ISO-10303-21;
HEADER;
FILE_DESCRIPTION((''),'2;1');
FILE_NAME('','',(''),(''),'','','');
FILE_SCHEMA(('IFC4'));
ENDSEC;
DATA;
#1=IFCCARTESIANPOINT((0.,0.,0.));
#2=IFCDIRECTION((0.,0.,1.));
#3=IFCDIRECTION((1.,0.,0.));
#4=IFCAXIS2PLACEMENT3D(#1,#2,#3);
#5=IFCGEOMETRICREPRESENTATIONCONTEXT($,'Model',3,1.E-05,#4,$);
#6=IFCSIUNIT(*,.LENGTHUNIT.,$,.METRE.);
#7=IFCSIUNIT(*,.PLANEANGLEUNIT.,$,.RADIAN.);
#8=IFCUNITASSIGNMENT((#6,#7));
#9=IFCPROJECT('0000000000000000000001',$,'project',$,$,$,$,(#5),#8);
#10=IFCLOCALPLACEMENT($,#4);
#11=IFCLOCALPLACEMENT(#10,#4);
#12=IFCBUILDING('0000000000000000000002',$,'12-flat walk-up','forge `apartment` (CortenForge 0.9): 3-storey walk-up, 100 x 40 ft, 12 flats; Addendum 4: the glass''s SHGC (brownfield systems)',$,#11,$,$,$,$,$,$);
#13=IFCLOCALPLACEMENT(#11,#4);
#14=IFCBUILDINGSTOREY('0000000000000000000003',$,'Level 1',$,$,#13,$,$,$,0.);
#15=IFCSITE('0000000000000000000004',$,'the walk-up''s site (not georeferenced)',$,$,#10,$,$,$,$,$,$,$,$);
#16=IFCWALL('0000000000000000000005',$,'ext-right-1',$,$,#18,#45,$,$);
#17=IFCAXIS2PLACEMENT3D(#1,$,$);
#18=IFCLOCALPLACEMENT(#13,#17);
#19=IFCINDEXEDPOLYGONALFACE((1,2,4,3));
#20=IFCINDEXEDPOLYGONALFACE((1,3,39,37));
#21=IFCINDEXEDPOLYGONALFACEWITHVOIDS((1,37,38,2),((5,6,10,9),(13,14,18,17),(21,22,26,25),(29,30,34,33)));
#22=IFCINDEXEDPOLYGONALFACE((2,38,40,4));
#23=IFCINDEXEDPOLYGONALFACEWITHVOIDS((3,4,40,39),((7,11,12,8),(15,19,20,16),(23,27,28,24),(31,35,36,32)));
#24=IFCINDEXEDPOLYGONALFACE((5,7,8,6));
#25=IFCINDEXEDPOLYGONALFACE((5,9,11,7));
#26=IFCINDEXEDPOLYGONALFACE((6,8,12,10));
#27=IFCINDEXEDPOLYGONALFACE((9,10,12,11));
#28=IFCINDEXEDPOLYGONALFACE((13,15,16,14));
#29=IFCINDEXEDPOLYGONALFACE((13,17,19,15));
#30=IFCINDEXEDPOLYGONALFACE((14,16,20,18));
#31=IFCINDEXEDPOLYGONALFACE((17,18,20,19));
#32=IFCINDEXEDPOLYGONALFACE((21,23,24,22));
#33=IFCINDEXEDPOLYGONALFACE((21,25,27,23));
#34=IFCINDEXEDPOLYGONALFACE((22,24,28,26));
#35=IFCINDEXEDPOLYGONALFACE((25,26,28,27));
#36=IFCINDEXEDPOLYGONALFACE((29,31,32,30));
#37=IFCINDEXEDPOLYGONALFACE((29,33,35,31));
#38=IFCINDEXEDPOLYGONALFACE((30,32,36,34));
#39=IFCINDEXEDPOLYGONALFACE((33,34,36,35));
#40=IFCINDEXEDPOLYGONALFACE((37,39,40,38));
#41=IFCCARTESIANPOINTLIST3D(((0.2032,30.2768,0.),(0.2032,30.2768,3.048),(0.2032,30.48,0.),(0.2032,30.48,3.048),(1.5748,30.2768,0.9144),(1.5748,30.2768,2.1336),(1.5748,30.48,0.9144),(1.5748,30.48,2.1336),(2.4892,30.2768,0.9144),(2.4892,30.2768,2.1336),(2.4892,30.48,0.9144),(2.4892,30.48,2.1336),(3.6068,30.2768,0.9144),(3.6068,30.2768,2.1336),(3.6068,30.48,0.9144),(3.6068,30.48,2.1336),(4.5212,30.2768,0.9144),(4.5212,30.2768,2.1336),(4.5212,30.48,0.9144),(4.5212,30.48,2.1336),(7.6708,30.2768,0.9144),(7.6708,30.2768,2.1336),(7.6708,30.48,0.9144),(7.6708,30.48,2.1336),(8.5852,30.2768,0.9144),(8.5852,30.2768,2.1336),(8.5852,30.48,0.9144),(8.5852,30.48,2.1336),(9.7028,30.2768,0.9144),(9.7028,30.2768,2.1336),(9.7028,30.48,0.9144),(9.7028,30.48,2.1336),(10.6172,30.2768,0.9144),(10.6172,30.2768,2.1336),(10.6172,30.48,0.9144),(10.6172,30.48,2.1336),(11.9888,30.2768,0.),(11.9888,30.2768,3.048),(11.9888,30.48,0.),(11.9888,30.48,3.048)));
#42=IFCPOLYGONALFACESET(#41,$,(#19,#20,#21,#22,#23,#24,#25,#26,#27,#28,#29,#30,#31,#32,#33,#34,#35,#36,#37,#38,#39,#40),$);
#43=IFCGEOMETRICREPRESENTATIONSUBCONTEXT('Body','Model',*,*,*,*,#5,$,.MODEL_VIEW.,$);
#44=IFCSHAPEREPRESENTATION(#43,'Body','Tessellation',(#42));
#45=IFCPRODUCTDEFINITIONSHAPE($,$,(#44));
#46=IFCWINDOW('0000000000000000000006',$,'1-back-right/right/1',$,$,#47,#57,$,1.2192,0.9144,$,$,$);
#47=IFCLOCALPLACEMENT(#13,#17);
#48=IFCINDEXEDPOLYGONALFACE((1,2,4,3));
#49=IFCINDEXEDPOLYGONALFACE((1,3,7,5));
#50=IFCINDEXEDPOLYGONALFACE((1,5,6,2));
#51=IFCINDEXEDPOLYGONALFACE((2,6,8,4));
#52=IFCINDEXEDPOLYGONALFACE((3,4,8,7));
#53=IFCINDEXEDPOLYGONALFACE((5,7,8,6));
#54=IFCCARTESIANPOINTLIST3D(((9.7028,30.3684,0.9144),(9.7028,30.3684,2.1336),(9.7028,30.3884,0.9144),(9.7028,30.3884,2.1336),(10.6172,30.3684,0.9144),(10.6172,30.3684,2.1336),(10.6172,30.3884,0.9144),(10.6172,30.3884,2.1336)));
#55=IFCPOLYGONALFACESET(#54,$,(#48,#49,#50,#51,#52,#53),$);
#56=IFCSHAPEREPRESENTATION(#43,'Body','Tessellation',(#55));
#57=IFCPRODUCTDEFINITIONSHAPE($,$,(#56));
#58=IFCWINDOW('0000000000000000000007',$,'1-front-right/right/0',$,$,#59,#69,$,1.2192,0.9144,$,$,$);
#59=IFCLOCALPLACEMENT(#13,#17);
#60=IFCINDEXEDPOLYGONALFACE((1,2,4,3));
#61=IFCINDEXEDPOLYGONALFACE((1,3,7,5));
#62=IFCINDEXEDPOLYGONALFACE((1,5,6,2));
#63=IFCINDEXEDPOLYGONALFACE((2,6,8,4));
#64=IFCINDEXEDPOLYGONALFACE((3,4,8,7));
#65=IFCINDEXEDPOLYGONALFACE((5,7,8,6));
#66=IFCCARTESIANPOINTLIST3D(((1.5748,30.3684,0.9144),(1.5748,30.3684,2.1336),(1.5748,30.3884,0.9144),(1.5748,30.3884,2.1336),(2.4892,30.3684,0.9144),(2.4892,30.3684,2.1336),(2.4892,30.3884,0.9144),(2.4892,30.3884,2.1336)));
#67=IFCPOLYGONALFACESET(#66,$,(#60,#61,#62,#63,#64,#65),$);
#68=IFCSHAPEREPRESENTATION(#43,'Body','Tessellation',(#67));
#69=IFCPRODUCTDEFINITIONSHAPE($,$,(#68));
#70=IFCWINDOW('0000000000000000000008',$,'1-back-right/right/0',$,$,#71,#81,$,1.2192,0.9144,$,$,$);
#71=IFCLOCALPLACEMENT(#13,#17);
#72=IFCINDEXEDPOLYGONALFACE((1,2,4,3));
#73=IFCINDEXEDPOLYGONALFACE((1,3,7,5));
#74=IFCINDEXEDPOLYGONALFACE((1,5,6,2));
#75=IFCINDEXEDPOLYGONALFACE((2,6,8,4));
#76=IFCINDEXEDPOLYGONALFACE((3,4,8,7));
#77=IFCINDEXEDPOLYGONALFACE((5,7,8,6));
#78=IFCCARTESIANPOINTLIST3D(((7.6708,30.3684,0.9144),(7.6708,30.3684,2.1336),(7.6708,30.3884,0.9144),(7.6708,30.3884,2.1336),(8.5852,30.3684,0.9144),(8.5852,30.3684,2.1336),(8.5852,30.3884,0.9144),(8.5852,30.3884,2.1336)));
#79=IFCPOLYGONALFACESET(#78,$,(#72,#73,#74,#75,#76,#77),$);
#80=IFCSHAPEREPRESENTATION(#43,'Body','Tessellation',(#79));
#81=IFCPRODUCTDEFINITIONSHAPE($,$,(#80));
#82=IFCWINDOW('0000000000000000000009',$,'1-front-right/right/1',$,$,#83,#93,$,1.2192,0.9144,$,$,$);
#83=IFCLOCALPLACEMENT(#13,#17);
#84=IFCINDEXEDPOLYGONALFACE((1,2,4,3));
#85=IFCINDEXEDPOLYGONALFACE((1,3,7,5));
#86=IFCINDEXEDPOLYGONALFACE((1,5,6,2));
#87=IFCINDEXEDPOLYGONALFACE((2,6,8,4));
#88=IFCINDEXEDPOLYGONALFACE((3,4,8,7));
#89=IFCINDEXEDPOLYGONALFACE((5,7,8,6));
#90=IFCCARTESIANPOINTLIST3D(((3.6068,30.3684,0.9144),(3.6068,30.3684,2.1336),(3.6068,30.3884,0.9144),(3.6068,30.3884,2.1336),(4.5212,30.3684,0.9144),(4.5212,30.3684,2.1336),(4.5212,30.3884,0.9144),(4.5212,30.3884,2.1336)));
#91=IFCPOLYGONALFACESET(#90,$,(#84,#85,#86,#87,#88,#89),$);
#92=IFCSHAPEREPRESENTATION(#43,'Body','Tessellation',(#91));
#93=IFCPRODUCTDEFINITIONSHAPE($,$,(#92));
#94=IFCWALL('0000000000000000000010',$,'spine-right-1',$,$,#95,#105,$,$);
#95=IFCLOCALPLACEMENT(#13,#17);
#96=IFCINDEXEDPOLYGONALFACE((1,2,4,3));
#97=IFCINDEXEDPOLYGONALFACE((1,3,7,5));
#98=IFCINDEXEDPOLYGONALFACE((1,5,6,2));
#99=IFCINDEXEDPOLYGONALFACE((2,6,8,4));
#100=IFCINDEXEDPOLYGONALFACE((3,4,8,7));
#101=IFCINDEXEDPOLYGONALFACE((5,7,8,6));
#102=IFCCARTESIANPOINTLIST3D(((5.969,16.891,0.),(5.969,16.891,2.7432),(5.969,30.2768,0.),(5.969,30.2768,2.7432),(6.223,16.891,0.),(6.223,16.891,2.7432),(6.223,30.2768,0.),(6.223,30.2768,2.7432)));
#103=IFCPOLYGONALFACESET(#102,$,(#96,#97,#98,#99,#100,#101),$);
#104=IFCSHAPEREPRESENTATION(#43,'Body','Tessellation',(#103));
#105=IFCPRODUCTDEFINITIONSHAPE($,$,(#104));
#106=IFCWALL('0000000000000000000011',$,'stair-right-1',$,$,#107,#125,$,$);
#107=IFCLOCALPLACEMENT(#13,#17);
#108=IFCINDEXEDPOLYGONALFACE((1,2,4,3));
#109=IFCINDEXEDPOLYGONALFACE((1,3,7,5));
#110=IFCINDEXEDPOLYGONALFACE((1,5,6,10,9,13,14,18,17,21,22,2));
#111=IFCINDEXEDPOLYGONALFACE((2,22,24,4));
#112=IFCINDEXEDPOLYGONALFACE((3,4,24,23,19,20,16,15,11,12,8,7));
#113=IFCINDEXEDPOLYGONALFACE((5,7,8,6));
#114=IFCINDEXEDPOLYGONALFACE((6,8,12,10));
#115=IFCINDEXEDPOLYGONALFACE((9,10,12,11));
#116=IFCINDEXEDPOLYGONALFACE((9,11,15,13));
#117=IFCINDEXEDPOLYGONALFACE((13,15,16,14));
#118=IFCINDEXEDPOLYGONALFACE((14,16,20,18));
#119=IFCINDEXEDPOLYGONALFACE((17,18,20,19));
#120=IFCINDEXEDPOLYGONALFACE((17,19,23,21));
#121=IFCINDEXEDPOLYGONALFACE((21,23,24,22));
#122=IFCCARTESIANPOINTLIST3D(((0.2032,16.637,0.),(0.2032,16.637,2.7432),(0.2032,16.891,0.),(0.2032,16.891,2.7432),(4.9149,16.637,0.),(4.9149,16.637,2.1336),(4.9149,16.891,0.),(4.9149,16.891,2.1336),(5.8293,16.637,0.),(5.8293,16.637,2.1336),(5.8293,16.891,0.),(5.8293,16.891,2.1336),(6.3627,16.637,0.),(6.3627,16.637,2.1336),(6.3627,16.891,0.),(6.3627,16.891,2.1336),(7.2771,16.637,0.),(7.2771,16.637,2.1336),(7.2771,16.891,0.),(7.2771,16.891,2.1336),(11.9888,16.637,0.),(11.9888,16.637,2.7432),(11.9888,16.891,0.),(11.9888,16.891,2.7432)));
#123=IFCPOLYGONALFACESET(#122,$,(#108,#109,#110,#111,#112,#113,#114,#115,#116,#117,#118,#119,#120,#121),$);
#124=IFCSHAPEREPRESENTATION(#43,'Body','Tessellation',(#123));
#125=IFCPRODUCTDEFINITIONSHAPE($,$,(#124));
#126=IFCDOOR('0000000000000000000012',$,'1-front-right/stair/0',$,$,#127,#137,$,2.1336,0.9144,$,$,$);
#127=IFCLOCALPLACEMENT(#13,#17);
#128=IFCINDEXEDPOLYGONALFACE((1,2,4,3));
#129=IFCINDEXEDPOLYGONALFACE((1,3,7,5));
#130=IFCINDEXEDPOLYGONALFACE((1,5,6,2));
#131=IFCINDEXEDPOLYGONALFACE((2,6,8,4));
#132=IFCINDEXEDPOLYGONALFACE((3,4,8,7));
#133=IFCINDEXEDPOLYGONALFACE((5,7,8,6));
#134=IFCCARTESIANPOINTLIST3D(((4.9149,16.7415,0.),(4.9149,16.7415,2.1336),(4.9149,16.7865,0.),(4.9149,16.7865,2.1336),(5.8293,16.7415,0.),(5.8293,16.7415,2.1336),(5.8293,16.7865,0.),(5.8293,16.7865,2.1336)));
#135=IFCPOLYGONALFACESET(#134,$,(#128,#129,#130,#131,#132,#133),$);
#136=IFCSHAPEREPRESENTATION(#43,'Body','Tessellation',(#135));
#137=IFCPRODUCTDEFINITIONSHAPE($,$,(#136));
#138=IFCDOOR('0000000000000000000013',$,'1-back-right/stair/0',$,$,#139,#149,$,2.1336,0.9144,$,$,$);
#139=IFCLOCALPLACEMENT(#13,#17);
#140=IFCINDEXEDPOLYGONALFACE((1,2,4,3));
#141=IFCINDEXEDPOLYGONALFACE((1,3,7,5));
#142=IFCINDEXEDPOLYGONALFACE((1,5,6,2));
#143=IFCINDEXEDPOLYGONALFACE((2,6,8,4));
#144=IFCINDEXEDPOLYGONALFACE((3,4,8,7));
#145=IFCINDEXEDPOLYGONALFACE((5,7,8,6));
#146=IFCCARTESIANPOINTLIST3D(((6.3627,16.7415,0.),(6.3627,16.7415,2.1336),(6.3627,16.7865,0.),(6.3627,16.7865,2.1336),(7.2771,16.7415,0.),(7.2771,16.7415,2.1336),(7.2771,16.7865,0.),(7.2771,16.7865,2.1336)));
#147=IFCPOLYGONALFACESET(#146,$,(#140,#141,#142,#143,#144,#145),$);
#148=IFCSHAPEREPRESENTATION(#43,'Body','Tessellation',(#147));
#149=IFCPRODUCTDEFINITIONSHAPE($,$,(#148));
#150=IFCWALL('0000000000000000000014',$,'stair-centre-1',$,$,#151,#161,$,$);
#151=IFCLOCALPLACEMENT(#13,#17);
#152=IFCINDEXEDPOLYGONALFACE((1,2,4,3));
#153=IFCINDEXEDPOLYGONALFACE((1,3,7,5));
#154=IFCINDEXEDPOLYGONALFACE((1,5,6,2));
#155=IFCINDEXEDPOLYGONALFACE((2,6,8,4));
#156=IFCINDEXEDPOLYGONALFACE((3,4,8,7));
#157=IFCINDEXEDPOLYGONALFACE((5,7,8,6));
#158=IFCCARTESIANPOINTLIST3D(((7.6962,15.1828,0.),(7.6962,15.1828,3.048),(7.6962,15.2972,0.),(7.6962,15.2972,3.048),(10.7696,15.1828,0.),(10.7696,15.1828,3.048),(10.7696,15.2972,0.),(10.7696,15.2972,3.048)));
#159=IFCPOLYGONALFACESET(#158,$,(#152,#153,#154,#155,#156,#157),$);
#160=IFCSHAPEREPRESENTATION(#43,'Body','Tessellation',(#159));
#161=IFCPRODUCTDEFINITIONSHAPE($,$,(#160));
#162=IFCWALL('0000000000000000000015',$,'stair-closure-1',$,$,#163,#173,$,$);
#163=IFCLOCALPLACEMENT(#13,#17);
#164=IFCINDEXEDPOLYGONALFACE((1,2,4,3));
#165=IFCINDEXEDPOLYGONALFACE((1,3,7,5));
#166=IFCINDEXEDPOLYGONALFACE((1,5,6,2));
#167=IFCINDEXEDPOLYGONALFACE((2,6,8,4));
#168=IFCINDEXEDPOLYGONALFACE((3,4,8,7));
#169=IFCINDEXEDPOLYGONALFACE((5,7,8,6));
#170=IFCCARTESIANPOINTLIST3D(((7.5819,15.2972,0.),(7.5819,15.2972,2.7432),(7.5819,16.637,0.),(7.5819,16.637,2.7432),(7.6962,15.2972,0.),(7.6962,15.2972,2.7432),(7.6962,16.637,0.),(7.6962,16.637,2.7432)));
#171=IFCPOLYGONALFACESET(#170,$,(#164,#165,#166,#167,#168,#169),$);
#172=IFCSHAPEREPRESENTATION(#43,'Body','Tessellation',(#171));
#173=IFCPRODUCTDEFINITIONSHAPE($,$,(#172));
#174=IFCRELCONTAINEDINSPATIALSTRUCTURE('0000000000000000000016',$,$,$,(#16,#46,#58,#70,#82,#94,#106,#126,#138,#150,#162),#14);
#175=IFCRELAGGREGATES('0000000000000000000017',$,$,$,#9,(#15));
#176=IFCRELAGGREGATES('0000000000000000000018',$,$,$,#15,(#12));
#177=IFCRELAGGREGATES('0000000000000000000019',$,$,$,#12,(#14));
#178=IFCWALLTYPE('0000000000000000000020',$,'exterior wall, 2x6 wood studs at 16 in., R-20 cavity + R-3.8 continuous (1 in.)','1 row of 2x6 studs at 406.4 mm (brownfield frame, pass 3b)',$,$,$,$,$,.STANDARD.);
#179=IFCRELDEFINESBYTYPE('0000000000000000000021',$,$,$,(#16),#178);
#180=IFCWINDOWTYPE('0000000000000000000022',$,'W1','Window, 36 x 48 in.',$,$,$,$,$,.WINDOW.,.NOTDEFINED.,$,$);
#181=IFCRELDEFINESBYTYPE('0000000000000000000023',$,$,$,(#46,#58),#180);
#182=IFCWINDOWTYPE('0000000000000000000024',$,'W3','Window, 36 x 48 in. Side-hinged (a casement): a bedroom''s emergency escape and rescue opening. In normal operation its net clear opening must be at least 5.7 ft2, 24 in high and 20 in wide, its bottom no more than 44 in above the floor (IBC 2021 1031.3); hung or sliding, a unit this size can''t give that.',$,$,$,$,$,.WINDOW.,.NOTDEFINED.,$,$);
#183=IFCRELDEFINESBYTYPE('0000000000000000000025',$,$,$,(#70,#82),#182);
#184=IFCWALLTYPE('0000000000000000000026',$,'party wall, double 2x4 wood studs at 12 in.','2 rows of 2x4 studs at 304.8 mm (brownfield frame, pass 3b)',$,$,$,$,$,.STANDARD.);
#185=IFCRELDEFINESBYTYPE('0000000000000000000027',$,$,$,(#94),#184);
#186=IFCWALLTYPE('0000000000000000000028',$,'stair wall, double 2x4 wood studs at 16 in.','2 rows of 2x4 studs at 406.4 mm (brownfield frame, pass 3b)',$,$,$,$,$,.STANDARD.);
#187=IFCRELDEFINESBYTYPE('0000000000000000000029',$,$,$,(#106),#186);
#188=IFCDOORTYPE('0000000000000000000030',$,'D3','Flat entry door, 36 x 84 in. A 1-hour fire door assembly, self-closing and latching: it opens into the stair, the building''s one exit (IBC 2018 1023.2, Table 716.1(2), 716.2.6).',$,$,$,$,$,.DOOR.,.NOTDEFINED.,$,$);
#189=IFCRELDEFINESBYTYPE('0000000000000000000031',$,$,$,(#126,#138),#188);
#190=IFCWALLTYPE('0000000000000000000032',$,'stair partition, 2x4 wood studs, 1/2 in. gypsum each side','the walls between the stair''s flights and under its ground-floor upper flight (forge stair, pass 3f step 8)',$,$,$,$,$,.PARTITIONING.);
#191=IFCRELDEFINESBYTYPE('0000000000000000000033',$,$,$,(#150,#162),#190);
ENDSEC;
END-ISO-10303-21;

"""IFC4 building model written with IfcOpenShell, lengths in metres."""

from ifc_helpers import new_model, si_unit, frame, frame_2d, origin, origin_with_axes, place, context, subcontext, project, spatial, rectangle, extrude, type_object, element, fill, save


model = new_model("IFC4")

# Units and contexts
model_context = context("Model", 3, precision=1e-05, world=origin_with_axes())
body_context = subcontext(model_context, "Body", "Model", "MODEL_VIEW")
ifc_project = project(units=[si_unit("LENGTHUNIT", "METRE"), si_unit("PLANEANGLEUNIT", "RADIAN")], contexts=[model_context])

# Site, building, storey
site_placement = place(None, origin_with_axes())
site = spatial("IfcSite", under=ifc_project, at=site_placement, Name="the walk-up's site (not georeferenced)")
building_placement = place(site_placement, origin_with_axes())
building = spatial("IfcBuilding", under=site, at=building_placement, Name="12-flat walk-up", Description="forge `apartment` (CortenForge 0.9): 3-storey walk-up, 100 x 40 ft, 12 flats; Addendum 4: the glass's SHGC (brownfield systems)")
storey_placement = place(building_placement, origin_with_axes())
storey = spatial("IfcBuildingStorey", under=building, at=storey_placement, Name="Level 1", Elevation=0.0)

# Wall, openings, windows
wall_type_1 = type_object("IfcWallType", Name="exterior wall, 2x6 wood studs at 16 in., R-20 cavity + R-3.8 continuous (1 in.)", Description="1 row of 2x6 studs at 406.4 mm (brownfield frame, pass 3b)", PredefinedType="STANDARD")
wall_1_placement = place(storey_placement, frame((0.2032, 30.2768, 0.0), z_axis=(0.0, 0.0, 1.0), x_axis=(1.0, 0.0, 0.0)))
wall_1 = element("IfcWall", 1, at=wall_1_placement, inside=storey, type_object=wall_type_1, Name="ext-right-1", context=body_context, shape_type="SweptSolid", body=[
    extrude(rectangle(XDim=11.7856, YDim=0.2032, at=frame_2d((5.8928, 0.1016))), origin(), (0.0, 0.0, 1.0), 3.048),
])
opening_1_placement = place(wall_1_placement, frame((8.382, 0.2032, 0.9144), z_axis=(0.0, 0.0, 1.0), x_axis=(-1.0, 0.0, 0.0)))
opening_1 = element("IfcOpeningElement", 2, at=opening_1_placement, cuts=wall_1, PredefinedType="OPENING", context=body_context, shape_type="SweptSolid", body=[
    extrude(rectangle(XDim=0.9144, YDim=0.2032, at=frame_2d((0.4572, 0.1016))), origin(), (0.0, 0.0, 1.0), 1.2192),
])
opening_2_placement = place(wall_1_placement, frame((10.414, 0.2032, 0.9144), z_axis=(0.0, 0.0, 1.0), x_axis=(-1.0, 0.0, 0.0)))
opening_2 = element("IfcOpeningElement", 3, at=opening_2_placement, cuts=wall_1, PredefinedType="OPENING", context=body_context, shape_type="SweptSolid", body=[
    extrude(rectangle(XDim=0.9144, YDim=0.2032, at=frame_2d((0.4572, 0.1016))), origin(), (0.0, 0.0, 1.0), 1.2192),
])
opening_3_placement = place(wall_1_placement, frame((2.286, 0.2032, 0.9144), z_axis=(0.0, 0.0, 1.0), x_axis=(-1.0, 0.0, 0.0)))
opening_3 = element("IfcOpeningElement", 4, at=opening_3_placement, cuts=wall_1, PredefinedType="OPENING", context=body_context, shape_type="SweptSolid", body=[
    extrude(rectangle(XDim=0.9144, YDim=0.2032, at=frame_2d((0.4572, 0.1016))), origin(), (0.0, 0.0, 1.0), 1.2192),
])
opening_4_placement = place(wall_1_placement, frame((4.318, 0.2032, 0.9144), z_axis=(0.0, 0.0, 1.0), x_axis=(-1.0, 0.0, 0.0)))
opening_4 = element("IfcOpeningElement", 5, at=opening_4_placement, cuts=wall_1, PredefinedType="OPENING", context=body_context, shape_type="SweptSolid", body=[
    extrude(rectangle(XDim=0.9144, YDim=0.2032, at=frame_2d((0.4572, 0.1016))), origin(), (0.0, 0.0, 1.0), 1.2192),
])
window_type_1 = type_object("IfcWindowType", Name="W1", Description="Window, 36 x 48 in.", PartitioningType="NOTDEFINED", PredefinedType="WINDOW")
window_1_placement = place(opening_2_placement, frame((0.0, 0.0916, 0.0), z_axis=(0.0, 0.0, 1.0), x_axis=(1.0, 0.0, 0.0)))
window_1 = element("IfcWindow", 6, at=window_1_placement, inside=storey, type_object=window_type_1, Name="1-back-right/right/1", OverallHeight=1.2192, OverallWidth=0.9144, context=body_context, shape_type="SweptSolid", body=[
    extrude(rectangle(XDim=0.9144, YDim=0.02, at=frame_2d((0.4572, 0.01))), origin(), (0.0, 0.0, 1.0), 1.2192),
])
fill(opening_2, window_1)
window_2_placement = place(opening_3_placement, frame((0.0, 0.0916, 0.0), z_axis=(0.0, 0.0, 1.0), x_axis=(1.0, 0.0, 0.0)))
window_2 = element("IfcWindow", 7, at=window_2_placement, inside=storey, type_object=window_type_1, Name="1-front-right/right/0", OverallHeight=1.2192, OverallWidth=0.9144, context=body_context, shape_type="SweptSolid", body=[
    extrude(rectangle(XDim=0.9144, YDim=0.02, at=frame_2d((0.4572, 0.01))), origin(), (0.0, 0.0, 1.0), 1.2192),
])
fill(opening_3, window_2)
window_type_2 = type_object("IfcWindowType", Name="W3", Description="Window, 36 x 48 in. Side-hinged (a casement): a bedroom's emergency escape and rescue opening. In normal operation its net clear opening must be at least 5.7 ft2, 24 in high and 20 in wide, its bottom no more than 44 in above the floor (IBC 2021 1031.3); hung or sliding, a unit this size can't give that.", PartitioningType="NOTDEFINED", PredefinedType="WINDOW")
window_3_placement = place(opening_1_placement, frame((0.0, 0.0916, 0.0), z_axis=(0.0, 0.0, 1.0), x_axis=(1.0, 0.0, 0.0)))
window_3 = element("IfcWindow", 8, at=window_3_placement, inside=storey, type_object=window_type_2, Name="1-back-right/right/0", OverallHeight=1.2192, OverallWidth=0.9144, context=body_context, shape_type="SweptSolid", body=[
    extrude(rectangle(XDim=0.9144, YDim=0.02, at=frame_2d((0.4572, 0.01))), origin(), (0.0, 0.0, 1.0), 1.2192),
])
fill(opening_1, window_3)
window_4_placement = place(opening_4_placement, frame((0.0, 0.0916, 0.0), z_axis=(0.0, 0.0, 1.0), x_axis=(1.0, 0.0, 0.0)))
window_4 = element("IfcWindow", 9, at=window_4_placement, inside=storey, type_object=window_type_2, Name="1-front-right/right/1", OverallHeight=1.2192, OverallWidth=0.9144, context=body_context, shape_type="SweptSolid", body=[
    extrude(rectangle(XDim=0.9144, YDim=0.02, at=frame_2d((0.4572, 0.01))), origin(), (0.0, 0.0, 1.0), 1.2192),
])
fill(opening_4, window_4)

# Wall
wall_type_2 = type_object("IfcWallType", Name="party wall, double 2x4 wood studs at 12 in.", Description="2 rows of 2x4 studs at 304.8 mm (brownfield frame, pass 3b)", PredefinedType="STANDARD")
wall_2_placement = place(storey_placement, frame((5.969, 16.891, 0.0), z_axis=(0.0, 0.0, 1.0), x_axis=(1.0, 0.0, 0.0)))
element("IfcWall", 10, at=wall_2_placement, inside=storey, type_object=wall_type_2, Name="spine-right-1", context=body_context, shape_type="SweptSolid", body=[
    extrude(rectangle(XDim=0.254, YDim=13.3858, at=frame_2d((0.127, 6.6929))), origin(), (0.0, 0.0, 1.0), 2.7432),
])

# Wall, openings, doors
wall_type_3 = type_object("IfcWallType", Name="stair wall, double 2x4 wood studs at 16 in.", Description="2 rows of 2x4 studs at 406.4 mm (brownfield frame, pass 3b)", PredefinedType="STANDARD")
wall_3_placement = place(storey_placement, frame((0.2032, 16.637, 0.0), z_axis=(0.0, 0.0, 1.0), x_axis=(1.0, 0.0, 0.0)))
wall_3 = element("IfcWall", 11, at=wall_3_placement, inside=storey, type_object=wall_type_3, Name="stair-right-1", context=body_context, shape_type="SweptSolid", body=[
    extrude(rectangle(XDim=11.7856, YDim=0.254, at=frame_2d((5.8928, 0.127))), origin(), (0.0, 0.0, 1.0), 2.7432),
])
opening_5_placement = place(wall_3_placement, frame((5.6261, 0.254, 0.0), z_axis=(0.0, 0.0, 1.0), x_axis=(-1.0, 0.0, 0.0)))
opening_5 = element("IfcOpeningElement", 12, at=opening_5_placement, cuts=wall_3, PredefinedType="OPENING", context=body_context, shape_type="SweptSolid", body=[
    extrude(rectangle(XDim=0.9144, YDim=0.254, at=frame_2d((0.4572, 0.127))), origin(), (0.0, 0.0, 1.0), 2.1336),
])
opening_6_placement = place(wall_3_placement, frame((7.0739, 0.254, 0.0), z_axis=(0.0, 0.0, 1.0), x_axis=(-1.0, 0.0, 0.0)))
opening_6 = element("IfcOpeningElement", 13, at=opening_6_placement, cuts=wall_3, PredefinedType="OPENING", context=body_context, shape_type="SweptSolid", body=[
    extrude(rectangle(XDim=0.9144, YDim=0.254, at=frame_2d((0.4572, 0.127))), origin(), (0.0, 0.0, 1.0), 2.1336),
])
door_type = type_object("IfcDoorType", Name="D3", Description="Flat entry door, 36 x 84 in. A 1-hour fire door assembly, self-closing and latching: it opens into the stair, the building's one exit (IBC 2018 1023.2, Table 716.1(2), 716.2.6).", OperationType="NOTDEFINED", PredefinedType="DOOR")
door_1_placement = place(opening_5_placement, frame((0.0, 0.1045, 0.0), z_axis=(0.0, 0.0, 1.0), x_axis=(1.0, 0.0, 0.0)))
door_1 = element("IfcDoor", 14, at=door_1_placement, inside=storey, type_object=door_type, Name="1-front-right/stair/0", OverallHeight=2.1336, OverallWidth=0.9144, context=body_context, shape_type="SweptSolid", body=[
    extrude(rectangle(XDim=0.9144, YDim=0.045, at=frame_2d((0.4572, 0.0225))), origin(), (0.0, 0.0, 1.0), 2.1336),
])
fill(opening_5, door_1)
door_2_placement = place(opening_6_placement, frame((0.0, 0.1045, 0.0), z_axis=(0.0, 0.0, 1.0), x_axis=(1.0, 0.0, 0.0)))
door_2 = element("IfcDoor", 15, at=door_2_placement, inside=storey, type_object=door_type, Name="1-back-right/stair/0", OverallHeight=2.1336, OverallWidth=0.9144, context=body_context, shape_type="SweptSolid", body=[
    extrude(rectangle(XDim=0.9144, YDim=0.045, at=frame_2d((0.4572, 0.0225))), origin(), (0.0, 0.0, 1.0), 2.1336),
])
fill(opening_6, door_2)

# Walls
wall_type_4 = type_object("IfcWallType", Name="stair partition, 2x4 wood studs, 1/2 in. gypsum each side", Description="the walls between the stair's flights and under its ground-floor upper flight (forge stair, pass 3f step 8)", PredefinedType="PARTITIONING")
wall_4_placement = place(storey_placement, frame((7.6962, 15.1829, 0.0), z_axis=(0.0, 0.0, 1.0), x_axis=(1.0, 0.0, 0.0)))
element("IfcWall", 16, at=wall_4_placement, inside=storey, type_object=wall_type_4, Name="stair-centre-1", context=body_context, shape_type="SweptSolid", body=[
    extrude(rectangle(XDim=3.0734, YDim=0.1143, at=frame_2d((1.5367, 0.0572))), origin(), (0.0, 0.0, 1.0), 3.048),
])
wall_5_placement = place(storey_placement, frame((7.5819, 15.2972, 0.0), z_axis=(0.0, 0.0, 1.0), x_axis=(1.0, 0.0, 0.0)))
element("IfcWall", 17, at=wall_5_placement, inside=storey, type_object=wall_type_4, Name="stair-closure-1", context=body_context, shape_type="SweptSolid", body=[
    extrude(rectangle(XDim=0.1143, YDim=1.3399, at=frame_2d((0.0572, 0.6699))), origin(), (0.0, 0.0, 1.0), 2.7432),
])

save(model, "model.ifc")
